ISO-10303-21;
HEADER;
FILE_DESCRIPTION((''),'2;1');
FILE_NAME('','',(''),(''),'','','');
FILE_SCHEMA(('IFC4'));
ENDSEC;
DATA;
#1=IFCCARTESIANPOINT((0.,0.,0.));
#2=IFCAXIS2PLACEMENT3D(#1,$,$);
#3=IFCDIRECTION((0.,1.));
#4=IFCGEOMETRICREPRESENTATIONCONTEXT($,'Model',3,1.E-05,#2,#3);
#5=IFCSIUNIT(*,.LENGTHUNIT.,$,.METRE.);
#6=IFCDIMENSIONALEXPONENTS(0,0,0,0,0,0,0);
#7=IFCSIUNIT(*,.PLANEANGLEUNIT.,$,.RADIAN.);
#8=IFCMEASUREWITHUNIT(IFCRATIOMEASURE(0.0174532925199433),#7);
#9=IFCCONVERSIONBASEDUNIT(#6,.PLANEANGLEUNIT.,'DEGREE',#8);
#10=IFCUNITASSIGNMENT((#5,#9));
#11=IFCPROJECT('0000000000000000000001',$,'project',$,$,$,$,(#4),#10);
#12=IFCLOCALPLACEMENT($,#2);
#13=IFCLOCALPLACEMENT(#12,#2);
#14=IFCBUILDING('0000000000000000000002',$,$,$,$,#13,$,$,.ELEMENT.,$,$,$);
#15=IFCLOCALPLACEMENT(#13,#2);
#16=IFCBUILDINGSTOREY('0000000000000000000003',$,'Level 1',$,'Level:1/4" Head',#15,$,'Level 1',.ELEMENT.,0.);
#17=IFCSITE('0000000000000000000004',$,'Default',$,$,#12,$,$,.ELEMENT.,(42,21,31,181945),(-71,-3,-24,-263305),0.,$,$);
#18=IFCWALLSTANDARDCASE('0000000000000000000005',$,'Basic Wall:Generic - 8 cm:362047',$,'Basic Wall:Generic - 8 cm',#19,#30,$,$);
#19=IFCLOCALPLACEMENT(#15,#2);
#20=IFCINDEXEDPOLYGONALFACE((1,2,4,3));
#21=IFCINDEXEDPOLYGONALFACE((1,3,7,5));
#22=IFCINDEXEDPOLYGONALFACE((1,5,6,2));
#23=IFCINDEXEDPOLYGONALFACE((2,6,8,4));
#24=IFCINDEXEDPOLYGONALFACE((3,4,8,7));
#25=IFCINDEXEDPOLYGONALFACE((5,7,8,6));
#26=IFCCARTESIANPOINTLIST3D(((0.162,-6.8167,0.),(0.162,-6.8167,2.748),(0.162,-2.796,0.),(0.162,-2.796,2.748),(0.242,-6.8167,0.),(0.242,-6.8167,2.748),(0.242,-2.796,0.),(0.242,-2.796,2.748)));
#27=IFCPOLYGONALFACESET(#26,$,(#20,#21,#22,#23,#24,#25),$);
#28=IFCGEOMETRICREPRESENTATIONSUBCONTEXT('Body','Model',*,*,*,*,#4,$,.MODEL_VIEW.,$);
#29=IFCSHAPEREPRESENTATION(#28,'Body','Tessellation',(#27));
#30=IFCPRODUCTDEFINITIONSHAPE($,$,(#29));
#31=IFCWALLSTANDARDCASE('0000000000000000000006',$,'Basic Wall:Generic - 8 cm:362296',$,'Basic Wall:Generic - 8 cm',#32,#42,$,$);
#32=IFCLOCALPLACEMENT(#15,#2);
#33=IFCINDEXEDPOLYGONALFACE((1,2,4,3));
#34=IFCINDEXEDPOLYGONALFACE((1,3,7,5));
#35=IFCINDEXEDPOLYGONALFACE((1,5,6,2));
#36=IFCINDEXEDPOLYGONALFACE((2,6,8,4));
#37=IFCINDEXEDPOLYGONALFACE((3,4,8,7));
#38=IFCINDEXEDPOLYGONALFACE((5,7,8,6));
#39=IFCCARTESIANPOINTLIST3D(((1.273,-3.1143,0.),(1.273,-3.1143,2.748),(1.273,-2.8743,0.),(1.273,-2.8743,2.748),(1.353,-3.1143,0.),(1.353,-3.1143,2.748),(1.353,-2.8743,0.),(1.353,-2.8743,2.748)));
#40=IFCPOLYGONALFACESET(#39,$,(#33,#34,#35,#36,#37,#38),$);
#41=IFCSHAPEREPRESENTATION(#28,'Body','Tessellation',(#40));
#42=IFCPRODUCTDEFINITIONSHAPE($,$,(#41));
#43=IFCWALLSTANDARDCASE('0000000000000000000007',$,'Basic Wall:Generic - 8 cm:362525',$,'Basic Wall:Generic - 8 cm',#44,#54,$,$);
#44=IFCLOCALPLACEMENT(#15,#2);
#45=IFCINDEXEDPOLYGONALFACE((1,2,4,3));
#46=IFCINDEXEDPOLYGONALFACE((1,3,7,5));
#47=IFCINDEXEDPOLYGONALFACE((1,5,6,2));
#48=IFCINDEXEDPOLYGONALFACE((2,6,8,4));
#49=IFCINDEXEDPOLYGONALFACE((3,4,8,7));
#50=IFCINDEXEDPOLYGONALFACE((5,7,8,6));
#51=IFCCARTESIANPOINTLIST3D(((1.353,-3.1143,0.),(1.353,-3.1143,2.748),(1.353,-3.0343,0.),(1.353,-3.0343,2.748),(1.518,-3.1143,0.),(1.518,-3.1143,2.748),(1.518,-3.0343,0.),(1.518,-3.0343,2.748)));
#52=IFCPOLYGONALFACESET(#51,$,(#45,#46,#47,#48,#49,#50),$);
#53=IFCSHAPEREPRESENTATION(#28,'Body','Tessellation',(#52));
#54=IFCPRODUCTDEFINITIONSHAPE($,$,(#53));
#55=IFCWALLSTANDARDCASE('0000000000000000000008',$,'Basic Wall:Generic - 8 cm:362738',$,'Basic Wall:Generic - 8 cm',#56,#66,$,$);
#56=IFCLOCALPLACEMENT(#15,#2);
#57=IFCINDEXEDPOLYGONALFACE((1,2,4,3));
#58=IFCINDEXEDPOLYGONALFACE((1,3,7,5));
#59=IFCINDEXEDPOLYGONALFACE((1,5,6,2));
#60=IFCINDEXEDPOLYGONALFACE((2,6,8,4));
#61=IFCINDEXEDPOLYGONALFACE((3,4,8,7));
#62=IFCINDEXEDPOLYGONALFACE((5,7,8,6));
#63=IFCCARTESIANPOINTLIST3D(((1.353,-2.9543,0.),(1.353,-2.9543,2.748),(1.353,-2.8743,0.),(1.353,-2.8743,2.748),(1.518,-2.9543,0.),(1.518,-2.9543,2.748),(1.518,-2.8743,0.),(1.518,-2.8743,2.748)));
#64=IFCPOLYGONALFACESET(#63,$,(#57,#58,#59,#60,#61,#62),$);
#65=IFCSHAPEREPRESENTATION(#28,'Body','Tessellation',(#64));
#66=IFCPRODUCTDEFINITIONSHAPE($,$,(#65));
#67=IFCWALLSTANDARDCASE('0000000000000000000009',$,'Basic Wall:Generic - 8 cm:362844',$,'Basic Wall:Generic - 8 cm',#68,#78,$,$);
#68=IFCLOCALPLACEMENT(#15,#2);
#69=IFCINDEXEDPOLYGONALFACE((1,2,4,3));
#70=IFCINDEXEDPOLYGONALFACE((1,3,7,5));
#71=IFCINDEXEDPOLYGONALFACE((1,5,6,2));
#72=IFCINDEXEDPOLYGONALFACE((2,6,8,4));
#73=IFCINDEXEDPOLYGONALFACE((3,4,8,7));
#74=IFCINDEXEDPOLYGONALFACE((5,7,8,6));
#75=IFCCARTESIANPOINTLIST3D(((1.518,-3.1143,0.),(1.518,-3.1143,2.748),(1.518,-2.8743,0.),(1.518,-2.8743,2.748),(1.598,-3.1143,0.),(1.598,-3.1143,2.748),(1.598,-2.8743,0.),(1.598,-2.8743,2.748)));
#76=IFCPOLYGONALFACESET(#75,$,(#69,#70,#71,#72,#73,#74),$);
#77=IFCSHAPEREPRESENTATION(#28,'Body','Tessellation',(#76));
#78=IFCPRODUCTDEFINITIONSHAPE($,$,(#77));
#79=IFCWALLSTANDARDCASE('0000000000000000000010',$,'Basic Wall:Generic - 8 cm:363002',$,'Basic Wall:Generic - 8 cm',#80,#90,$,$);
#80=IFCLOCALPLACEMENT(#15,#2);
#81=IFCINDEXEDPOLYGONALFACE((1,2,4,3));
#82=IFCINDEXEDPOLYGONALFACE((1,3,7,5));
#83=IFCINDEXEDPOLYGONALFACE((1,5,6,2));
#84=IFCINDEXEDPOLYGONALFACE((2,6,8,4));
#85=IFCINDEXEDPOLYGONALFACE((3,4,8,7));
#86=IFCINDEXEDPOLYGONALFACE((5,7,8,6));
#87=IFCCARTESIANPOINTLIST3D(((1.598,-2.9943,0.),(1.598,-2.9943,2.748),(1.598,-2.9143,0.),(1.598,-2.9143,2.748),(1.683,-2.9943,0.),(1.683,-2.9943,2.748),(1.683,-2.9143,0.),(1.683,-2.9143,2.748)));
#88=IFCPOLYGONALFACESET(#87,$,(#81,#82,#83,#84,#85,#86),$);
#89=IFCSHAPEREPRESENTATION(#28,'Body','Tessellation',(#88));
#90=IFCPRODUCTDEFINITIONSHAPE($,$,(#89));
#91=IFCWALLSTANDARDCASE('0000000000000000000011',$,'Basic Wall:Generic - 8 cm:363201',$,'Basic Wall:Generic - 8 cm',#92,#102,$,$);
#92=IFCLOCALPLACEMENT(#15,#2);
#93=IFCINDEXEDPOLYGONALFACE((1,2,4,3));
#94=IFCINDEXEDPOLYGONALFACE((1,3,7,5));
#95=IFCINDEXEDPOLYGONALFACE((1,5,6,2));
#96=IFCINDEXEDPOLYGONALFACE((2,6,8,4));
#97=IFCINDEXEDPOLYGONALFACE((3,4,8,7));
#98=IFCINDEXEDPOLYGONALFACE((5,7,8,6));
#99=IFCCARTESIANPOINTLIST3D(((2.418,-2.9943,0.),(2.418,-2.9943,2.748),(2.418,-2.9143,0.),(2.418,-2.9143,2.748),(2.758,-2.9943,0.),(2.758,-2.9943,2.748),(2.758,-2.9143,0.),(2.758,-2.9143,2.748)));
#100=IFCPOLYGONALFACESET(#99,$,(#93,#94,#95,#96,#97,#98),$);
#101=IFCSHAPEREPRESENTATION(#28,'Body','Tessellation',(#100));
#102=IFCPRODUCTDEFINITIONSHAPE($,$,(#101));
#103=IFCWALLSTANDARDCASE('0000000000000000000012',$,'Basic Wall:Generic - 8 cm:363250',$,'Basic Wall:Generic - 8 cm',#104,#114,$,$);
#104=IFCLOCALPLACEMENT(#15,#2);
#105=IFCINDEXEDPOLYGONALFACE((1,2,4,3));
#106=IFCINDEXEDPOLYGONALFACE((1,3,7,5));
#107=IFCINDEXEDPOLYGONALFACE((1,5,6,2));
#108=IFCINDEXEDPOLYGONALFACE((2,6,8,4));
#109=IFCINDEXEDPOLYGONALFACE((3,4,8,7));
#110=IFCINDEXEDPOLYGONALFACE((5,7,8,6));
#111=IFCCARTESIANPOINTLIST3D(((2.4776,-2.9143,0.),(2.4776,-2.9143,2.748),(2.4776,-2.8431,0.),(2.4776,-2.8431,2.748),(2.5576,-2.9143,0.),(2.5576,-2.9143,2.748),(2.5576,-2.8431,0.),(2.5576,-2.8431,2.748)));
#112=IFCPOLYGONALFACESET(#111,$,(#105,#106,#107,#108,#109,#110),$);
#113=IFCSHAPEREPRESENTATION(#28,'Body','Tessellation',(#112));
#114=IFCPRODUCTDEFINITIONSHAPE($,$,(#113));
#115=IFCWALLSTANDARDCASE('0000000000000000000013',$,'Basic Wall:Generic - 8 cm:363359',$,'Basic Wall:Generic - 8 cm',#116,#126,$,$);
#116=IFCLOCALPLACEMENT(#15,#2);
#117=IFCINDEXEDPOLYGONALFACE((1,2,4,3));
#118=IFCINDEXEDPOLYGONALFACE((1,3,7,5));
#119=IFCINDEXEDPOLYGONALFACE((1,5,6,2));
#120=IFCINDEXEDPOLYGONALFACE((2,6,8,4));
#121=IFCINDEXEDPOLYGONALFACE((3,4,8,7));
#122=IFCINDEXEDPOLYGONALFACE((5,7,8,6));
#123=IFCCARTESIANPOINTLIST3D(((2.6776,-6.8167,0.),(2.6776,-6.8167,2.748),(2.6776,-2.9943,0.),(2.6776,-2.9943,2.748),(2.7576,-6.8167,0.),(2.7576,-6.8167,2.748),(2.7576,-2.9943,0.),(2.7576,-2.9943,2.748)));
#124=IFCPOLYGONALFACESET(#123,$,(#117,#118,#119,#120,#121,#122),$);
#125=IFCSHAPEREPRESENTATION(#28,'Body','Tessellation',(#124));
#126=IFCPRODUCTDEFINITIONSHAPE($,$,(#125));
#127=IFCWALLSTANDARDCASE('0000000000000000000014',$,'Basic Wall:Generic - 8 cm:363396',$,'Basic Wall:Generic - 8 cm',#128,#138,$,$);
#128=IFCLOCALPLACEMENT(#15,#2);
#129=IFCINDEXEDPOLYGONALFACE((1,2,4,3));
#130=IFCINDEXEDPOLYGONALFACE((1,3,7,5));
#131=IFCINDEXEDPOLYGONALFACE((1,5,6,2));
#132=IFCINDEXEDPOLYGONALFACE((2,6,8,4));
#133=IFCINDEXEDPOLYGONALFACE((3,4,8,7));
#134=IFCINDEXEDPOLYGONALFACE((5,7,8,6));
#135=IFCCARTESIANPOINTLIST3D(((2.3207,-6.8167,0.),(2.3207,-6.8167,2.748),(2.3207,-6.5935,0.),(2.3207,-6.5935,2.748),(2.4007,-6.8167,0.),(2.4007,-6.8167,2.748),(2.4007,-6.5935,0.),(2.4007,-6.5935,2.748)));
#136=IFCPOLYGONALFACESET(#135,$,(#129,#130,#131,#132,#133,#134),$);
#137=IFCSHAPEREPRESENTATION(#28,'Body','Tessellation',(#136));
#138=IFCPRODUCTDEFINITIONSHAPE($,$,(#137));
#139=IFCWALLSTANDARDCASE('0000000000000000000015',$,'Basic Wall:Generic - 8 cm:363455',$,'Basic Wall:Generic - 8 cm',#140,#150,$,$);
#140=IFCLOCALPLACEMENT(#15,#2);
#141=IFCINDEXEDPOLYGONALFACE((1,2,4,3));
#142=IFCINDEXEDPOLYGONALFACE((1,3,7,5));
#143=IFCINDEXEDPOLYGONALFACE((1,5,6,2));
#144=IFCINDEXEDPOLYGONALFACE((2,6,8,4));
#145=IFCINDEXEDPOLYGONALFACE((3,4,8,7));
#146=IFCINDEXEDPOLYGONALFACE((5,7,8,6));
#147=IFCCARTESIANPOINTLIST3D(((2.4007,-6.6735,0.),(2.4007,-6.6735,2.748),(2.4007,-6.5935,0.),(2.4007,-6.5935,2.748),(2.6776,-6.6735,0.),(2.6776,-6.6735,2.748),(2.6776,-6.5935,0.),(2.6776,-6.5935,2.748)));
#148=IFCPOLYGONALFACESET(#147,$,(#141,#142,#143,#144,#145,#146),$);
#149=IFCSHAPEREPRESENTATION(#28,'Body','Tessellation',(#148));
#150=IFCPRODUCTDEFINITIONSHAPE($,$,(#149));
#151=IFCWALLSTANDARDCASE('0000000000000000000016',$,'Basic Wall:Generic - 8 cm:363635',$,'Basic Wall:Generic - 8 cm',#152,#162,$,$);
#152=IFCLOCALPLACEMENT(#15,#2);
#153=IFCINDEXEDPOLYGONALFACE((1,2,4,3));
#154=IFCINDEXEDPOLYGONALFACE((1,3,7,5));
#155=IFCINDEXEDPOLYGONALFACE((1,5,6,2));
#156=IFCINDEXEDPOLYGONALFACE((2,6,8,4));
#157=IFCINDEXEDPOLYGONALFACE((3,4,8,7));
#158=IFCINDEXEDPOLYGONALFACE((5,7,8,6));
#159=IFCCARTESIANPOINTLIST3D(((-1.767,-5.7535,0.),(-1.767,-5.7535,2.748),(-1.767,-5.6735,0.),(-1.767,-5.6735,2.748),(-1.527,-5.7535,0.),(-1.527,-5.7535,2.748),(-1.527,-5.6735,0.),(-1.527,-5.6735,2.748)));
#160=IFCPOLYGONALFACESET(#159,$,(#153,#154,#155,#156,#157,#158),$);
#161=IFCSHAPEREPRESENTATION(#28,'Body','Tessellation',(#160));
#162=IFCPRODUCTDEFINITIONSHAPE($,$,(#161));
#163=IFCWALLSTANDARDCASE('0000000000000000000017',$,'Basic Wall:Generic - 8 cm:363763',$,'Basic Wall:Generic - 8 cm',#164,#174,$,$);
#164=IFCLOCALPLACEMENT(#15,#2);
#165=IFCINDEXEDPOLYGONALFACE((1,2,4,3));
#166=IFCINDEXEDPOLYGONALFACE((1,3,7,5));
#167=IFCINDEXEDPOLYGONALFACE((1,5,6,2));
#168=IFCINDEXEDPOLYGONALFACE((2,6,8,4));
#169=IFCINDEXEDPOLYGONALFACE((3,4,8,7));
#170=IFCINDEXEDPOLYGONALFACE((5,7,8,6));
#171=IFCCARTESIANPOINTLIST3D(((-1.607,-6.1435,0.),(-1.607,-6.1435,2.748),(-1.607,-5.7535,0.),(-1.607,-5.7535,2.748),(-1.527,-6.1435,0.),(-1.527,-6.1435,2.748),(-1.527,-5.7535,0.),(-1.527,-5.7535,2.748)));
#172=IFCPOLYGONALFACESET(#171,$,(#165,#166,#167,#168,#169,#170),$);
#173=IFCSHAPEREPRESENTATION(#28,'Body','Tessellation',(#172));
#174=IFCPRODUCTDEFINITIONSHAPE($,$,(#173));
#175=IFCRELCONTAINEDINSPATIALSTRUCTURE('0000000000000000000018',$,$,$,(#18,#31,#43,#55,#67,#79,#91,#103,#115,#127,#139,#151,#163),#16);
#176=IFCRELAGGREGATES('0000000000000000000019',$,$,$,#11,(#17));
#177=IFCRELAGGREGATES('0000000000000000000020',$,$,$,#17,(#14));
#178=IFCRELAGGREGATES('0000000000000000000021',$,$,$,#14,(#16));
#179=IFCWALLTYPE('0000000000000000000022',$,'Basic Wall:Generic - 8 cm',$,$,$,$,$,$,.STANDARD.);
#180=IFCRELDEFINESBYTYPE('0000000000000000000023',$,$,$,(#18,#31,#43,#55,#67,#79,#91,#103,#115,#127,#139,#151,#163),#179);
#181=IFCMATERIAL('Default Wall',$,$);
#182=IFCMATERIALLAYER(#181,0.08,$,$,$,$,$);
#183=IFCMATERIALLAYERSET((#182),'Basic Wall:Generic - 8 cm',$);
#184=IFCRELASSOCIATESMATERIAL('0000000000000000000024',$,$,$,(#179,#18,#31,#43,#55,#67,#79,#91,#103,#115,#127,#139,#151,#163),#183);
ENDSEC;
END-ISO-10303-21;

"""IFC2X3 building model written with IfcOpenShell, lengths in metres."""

from ifc_helpers import new_model, entity, si_unit, converted_unit, direction, frame, frame_2d, origin, place, context, subcontext, project, spatial, rectangle, extrude, material, layer, layer_set, layer_usage, type_object, element, save


model = new_model("IFC2X3")

# Units and contexts
model_context = context("Model", 3, precision=1e-05, world=origin(), true_north=direction((0.0, 1.0)))
body_context = subcontext(model_context, "Body", "Model", "MODEL_VIEW")
ifc_project = project(units=[si_unit("LENGTHUNIT", "METRE"), converted_unit("PLANEANGLEUNIT", "DEGREE", entity("IfcRatioMeasure", 0.0174532925199433), si_unit("PLANEANGLEUNIT", "RADIAN"), dimensions=[0, 0, 0, 0, 0, 0, 0])], contexts=[model_context])

# Site, building, storey
site_placement = place(None, origin())
site = spatial("IfcSite", under=ifc_project, at=site_placement, Name="Default", CompositionType="ELEMENT", RefLatitude=(42, 21, 31, 181945), RefLongitude=(-71, -3, -24, -263305), RefElevation=0.0)
building_placement = place(site_placement, origin())
building = spatial("IfcBuilding", under=site, at=building_placement, CompositionType="ELEMENT")
storey_placement = place(building_placement, origin())
storey = spatial("IfcBuildingStorey", under=building, at=storey_placement, Name="Level 1", ObjectType="Level:1/4\" Head", LongName="Level 1", CompositionType="ELEMENT", Elevation=0.0)

# Walls
ifc_material = material(Name="Default Wall")
ifc_layer = layer(ifc_material, 0.08)
ifc_layer_set = layer_set([ifc_layer], Name="Basic Wall:Generic - 8 cm")
wall_type = type_object("IfcWallType", Name="Basic Wall:Generic - 8 cm", PredefinedType="STANDARD", material=ifc_layer_set)
ifc_layer_usage_1 = layer_usage(ifc_layer_set, "AXIS2", "NEGATIVE", 0.04)
wall_1_placement = place(storey_placement, frame((0.202, -2.796, 0.0), z_axis=(0.0, 0.0, 1.0), x_axis=(0.0, -1.0, 0.0)))
element("IfcWallStandardCase", 1, at=wall_1_placement, inside=storey, type_object=wall_type, material=ifc_layer_usage_1, Name="Basic Wall:Generic - 8 cm:362047", ObjectType="Basic Wall:Generic - 8 cm", context=body_context, shape_type="SweptSolid", body=[
    extrude(rectangle(XDim=4.0208, YDim=0.08, at=frame_2d((2.0104, 0.0), x_axis=(-1.0, 0.0))), origin(), (0.0, 0.0, 1.0), 2.748),
])
ifc_layer_usage_2 = layer_usage(ifc_layer_set, "AXIS2", "NEGATIVE", 0.04)
wall_2_placement = place(storey_placement, frame((1.313, -2.8743, 0.0), z_axis=(0.0, 0.0, 1.0), x_axis=(0.0, -1.0, 0.0)))
element("IfcWallStandardCase", 2, at=wall_2_placement, inside=storey, type_object=wall_type, material=ifc_layer_usage_2, Name="Basic Wall:Generic - 8 cm:362296", ObjectType="Basic Wall:Generic - 8 cm", context=body_context, shape_type="SweptSolid", body=[
    extrude(rectangle(XDim=0.24, YDim=0.08, at=frame_2d((0.12, 0.0), x_axis=(-1.0, 0.0))), origin(), (0.0, 0.0, 1.0), 2.748),
])
ifc_layer_usage_3 = layer_usage(ifc_layer_set, "AXIS2", "NEGATIVE", 0.04)
wall_3_placement = place(storey_placement, frame((1.353, -3.0743, 0.0)))
element("IfcWallStandardCase", 3, at=wall_3_placement, inside=storey, type_object=wall_type, material=ifc_layer_usage_3, Name="Basic Wall:Generic - 8 cm:362525", ObjectType="Basic Wall:Generic - 8 cm", context=body_context, shape_type="SweptSolid", body=[
    extrude(rectangle(XDim=0.165, YDim=0.08, at=frame_2d((0.0825, 0.0), x_axis=(-1.0, 0.0))), origin(), (0.0, 0.0, 1.0), 2.748),
])
ifc_layer_usage_4 = layer_usage(ifc_layer_set, "AXIS2", "NEGATIVE", 0.04)
wall_4_placement = place(storey_placement, frame((1.353, -2.9143, 0.0)))
element("IfcWallStandardCase", 4, at=wall_4_placement, inside=storey, type_object=wall_type, material=ifc_layer_usage_4, Name="Basic Wall:Generic - 8 cm:362738", ObjectType="Basic Wall:Generic - 8 cm", context=body_context, shape_type="SweptSolid", body=[
    extrude(rectangle(XDim=0.165, YDim=0.08, at=frame_2d((0.0825, 0.0), x_axis=(-1.0, 0.0))), origin(), (0.0, 0.0, 1.0), 2.748),
])
ifc_layer_usage_5 = layer_usage(ifc_layer_set, "AXIS2", "NEGATIVE", 0.04)
wall_5_placement = place(storey_placement, frame((1.558, -3.1143, 0.0), z_axis=(0.0, 0.0, 1.0), x_axis=(0.0, 1.0, 0.0)))
element("IfcWallStandardCase", 5, at=wall_5_placement, inside=storey, type_object=wall_type, material=ifc_layer_usage_5, Name="Basic Wall:Generic - 8 cm:362844", ObjectType="Basic Wall:Generic - 8 cm", context=body_context, shape_type="SweptSolid", body=[
    extrude(rectangle(XDim=0.24, YDim=0.08, at=frame_2d((0.12, 0.0), x_axis=(-1.0, 0.0))), origin(), (0.0, 0.0, 1.0), 2.748),
])
ifc_layer_usage_6 = layer_usage(ifc_layer_set, "AXIS2", "NEGATIVE", 0.04)
wall_6_placement = place(storey_placement, frame((1.598, -2.9543, 0.0)))
element("IfcWallStandardCase", 6, at=wall_6_placement, inside=storey, type_object=wall_type, material=ifc_layer_usage_6, Name="Basic Wall:Generic - 8 cm:363002", ObjectType="Basic Wall:Generic - 8 cm", context=body_context, shape_type="SweptSolid", body=[
    extrude(rectangle(XDim=0.085, YDim=0.08, at=frame_2d((0.0425, 0.0), x_axis=(-1.0, 0.0))), origin(), (0.0, 0.0, 1.0), 2.748),
])
ifc_layer_usage_7 = layer_usage(ifc_layer_set, "AXIS2", "NEGATIVE", 0.04)
wall_7_placement = place(storey_placement, frame((2.418, -2.9543, 0.0)))
element("IfcWallStandardCase", 7, at=wall_7_placement, inside=storey, type_object=wall_type, material=ifc_layer_usage_7, Name="Basic Wall:Generic - 8 cm:363201", ObjectType="Basic Wall:Generic - 8 cm", context=body_context, shape_type="SweptSolid", body=[
    extrude(rectangle(XDim=0.34, YDim=0.08, at=frame_2d((0.17, 0.0), x_axis=(-1.0, 0.0))), origin(), (0.0, 0.0, 1.0), 2.748),
])
ifc_layer_usage_8 = layer_usage(ifc_layer_set, "AXIS2", "NEGATIVE", 0.04)
wall_8_placement = place(storey_placement, frame((2.5176, -2.8431, 0.0), z_axis=(0.0, 0.0, 1.0), x_axis=(0.0, -1.0, 0.0)))
element("IfcWallStandardCase", 8, at=wall_8_placement, inside=storey, type_object=wall_type, material=ifc_layer_usage_8, Name="Basic Wall:Generic - 8 cm:363250", ObjectType="Basic Wall:Generic - 8 cm", context=body_context, shape_type="SweptSolid", body=[
    extrude(rectangle(XDim=0.0712, YDim=0.08, at=frame_2d((0.0356, 0.0), x_axis=(-1.0, 0.0))), origin(), (0.0, 0.0, 1.0), 2.748),
])
ifc_layer_usage_9 = layer_usage(ifc_layer_set, "AXIS2", "NEGATIVE", 0.04)
wall_9_placement = place(storey_placement, frame((2.7176, -2.9943, 0.0), z_axis=(0.0, 0.0, 1.0), x_axis=(0.0, -1.0, 0.0)))
element("IfcWallStandardCase", 9, at=wall_9_placement, inside=storey, type_object=wall_type, material=ifc_layer_usage_9, Name="Basic Wall:Generic - 8 cm:363359", ObjectType="Basic Wall:Generic - 8 cm", context=body_context, shape_type="SweptSolid", body=[
    extrude(rectangle(XDim=3.8224, YDim=0.08, at=frame_2d((1.9112, 0.0), x_axis=(-1.0, 0.0))), origin(), (0.0, 0.0, 1.0), 2.748),
])
ifc_layer_usage_10 = layer_usage(ifc_layer_set, "AXIS2", "NEGATIVE", 0.04)
wall_10_placement = place(storey_placement, frame((2.3607, -6.5935, 0.0), z_axis=(0.0, 0.0, 1.0), x_axis=(0.0, -1.0, 0.0)))
element("IfcWallStandardCase", 10, at=wall_10_placement, inside=storey, type_object=wall_type, material=ifc_layer_usage_10, Name="Basic Wall:Generic - 8 cm:363396", ObjectType="Basic Wall:Generic - 8 cm", context=body_context, shape_type="SweptSolid", body=[
    extrude(rectangle(XDim=0.2232, YDim=0.08, at=frame_2d((0.1116, 0.0), x_axis=(-1.0, 0.0))), origin(), (0.0, 0.0, 1.0), 2.748),
])
ifc_layer_usage_11 = layer_usage(ifc_layer_set, "AXIS2", "NEGATIVE", 0.04)
wall_11_placement = place(storey_placement, frame((2.4007, -6.6335, 0.0)))
element("IfcWallStandardCase", 11, at=wall_11_placement, inside=storey, type_object=wall_type, material=ifc_layer_usage_11, Name="Basic Wall:Generic - 8 cm:363455", ObjectType="Basic Wall:Generic - 8 cm", context=body_context, shape_type="SweptSolid", body=[
    extrude(rectangle(XDim=0.277, YDim=0.08, at=frame_2d((0.1385, 0.0), x_axis=(-1.0, 0.0))), origin(), (0.0, 0.0, 1.0), 2.748),
])
ifc_layer_usage_12 = layer_usage(ifc_layer_set, "AXIS2", "NEGATIVE", 0.04)
wall_12_placement = place(storey_placement, frame((-1.767, -5.7135, 0.0)))
element("IfcWallStandardCase", 12, at=wall_12_placement, inside=storey, type_object=wall_type, material=ifc_layer_usage_12, Name="Basic Wall:Generic - 8 cm:363635", ObjectType="Basic Wall:Generic - 8 cm", context=body_context, shape_type="SweptSolid", body=[
    extrude(rectangle(XDim=0.24, YDim=0.08, at=frame_2d((0.12, 0.0), x_axis=(-1.0, 0.0))), origin(), (0.0, 0.0, 1.0), 2.748),
])
ifc_layer_usage_13 = layer_usage(ifc_layer_set, "AXIS2", "NEGATIVE", 0.04)
wall_13_placement = place(storey_placement, frame((-1.567, -5.7535, 0.0), z_axis=(0.0, 0.0, 1.0), x_axis=(0.0, -1.0, 0.0)))
element("IfcWallStandardCase", 13, at=wall_13_placement, inside=storey, type_object=wall_type, material=ifc_layer_usage_13, Name="Basic Wall:Generic - 8 cm:363763", ObjectType="Basic Wall:Generic - 8 cm", context=body_context, shape_type="SweptSolid", body=[
    extrude(rectangle(XDim=0.39, YDim=0.08, at=frame_2d((0.195, 0.0), x_axis=(-1.0, 0.0))), origin(), (0.0, 0.0, 1.0), 2.748),
])

save(model, "model.ifc")
